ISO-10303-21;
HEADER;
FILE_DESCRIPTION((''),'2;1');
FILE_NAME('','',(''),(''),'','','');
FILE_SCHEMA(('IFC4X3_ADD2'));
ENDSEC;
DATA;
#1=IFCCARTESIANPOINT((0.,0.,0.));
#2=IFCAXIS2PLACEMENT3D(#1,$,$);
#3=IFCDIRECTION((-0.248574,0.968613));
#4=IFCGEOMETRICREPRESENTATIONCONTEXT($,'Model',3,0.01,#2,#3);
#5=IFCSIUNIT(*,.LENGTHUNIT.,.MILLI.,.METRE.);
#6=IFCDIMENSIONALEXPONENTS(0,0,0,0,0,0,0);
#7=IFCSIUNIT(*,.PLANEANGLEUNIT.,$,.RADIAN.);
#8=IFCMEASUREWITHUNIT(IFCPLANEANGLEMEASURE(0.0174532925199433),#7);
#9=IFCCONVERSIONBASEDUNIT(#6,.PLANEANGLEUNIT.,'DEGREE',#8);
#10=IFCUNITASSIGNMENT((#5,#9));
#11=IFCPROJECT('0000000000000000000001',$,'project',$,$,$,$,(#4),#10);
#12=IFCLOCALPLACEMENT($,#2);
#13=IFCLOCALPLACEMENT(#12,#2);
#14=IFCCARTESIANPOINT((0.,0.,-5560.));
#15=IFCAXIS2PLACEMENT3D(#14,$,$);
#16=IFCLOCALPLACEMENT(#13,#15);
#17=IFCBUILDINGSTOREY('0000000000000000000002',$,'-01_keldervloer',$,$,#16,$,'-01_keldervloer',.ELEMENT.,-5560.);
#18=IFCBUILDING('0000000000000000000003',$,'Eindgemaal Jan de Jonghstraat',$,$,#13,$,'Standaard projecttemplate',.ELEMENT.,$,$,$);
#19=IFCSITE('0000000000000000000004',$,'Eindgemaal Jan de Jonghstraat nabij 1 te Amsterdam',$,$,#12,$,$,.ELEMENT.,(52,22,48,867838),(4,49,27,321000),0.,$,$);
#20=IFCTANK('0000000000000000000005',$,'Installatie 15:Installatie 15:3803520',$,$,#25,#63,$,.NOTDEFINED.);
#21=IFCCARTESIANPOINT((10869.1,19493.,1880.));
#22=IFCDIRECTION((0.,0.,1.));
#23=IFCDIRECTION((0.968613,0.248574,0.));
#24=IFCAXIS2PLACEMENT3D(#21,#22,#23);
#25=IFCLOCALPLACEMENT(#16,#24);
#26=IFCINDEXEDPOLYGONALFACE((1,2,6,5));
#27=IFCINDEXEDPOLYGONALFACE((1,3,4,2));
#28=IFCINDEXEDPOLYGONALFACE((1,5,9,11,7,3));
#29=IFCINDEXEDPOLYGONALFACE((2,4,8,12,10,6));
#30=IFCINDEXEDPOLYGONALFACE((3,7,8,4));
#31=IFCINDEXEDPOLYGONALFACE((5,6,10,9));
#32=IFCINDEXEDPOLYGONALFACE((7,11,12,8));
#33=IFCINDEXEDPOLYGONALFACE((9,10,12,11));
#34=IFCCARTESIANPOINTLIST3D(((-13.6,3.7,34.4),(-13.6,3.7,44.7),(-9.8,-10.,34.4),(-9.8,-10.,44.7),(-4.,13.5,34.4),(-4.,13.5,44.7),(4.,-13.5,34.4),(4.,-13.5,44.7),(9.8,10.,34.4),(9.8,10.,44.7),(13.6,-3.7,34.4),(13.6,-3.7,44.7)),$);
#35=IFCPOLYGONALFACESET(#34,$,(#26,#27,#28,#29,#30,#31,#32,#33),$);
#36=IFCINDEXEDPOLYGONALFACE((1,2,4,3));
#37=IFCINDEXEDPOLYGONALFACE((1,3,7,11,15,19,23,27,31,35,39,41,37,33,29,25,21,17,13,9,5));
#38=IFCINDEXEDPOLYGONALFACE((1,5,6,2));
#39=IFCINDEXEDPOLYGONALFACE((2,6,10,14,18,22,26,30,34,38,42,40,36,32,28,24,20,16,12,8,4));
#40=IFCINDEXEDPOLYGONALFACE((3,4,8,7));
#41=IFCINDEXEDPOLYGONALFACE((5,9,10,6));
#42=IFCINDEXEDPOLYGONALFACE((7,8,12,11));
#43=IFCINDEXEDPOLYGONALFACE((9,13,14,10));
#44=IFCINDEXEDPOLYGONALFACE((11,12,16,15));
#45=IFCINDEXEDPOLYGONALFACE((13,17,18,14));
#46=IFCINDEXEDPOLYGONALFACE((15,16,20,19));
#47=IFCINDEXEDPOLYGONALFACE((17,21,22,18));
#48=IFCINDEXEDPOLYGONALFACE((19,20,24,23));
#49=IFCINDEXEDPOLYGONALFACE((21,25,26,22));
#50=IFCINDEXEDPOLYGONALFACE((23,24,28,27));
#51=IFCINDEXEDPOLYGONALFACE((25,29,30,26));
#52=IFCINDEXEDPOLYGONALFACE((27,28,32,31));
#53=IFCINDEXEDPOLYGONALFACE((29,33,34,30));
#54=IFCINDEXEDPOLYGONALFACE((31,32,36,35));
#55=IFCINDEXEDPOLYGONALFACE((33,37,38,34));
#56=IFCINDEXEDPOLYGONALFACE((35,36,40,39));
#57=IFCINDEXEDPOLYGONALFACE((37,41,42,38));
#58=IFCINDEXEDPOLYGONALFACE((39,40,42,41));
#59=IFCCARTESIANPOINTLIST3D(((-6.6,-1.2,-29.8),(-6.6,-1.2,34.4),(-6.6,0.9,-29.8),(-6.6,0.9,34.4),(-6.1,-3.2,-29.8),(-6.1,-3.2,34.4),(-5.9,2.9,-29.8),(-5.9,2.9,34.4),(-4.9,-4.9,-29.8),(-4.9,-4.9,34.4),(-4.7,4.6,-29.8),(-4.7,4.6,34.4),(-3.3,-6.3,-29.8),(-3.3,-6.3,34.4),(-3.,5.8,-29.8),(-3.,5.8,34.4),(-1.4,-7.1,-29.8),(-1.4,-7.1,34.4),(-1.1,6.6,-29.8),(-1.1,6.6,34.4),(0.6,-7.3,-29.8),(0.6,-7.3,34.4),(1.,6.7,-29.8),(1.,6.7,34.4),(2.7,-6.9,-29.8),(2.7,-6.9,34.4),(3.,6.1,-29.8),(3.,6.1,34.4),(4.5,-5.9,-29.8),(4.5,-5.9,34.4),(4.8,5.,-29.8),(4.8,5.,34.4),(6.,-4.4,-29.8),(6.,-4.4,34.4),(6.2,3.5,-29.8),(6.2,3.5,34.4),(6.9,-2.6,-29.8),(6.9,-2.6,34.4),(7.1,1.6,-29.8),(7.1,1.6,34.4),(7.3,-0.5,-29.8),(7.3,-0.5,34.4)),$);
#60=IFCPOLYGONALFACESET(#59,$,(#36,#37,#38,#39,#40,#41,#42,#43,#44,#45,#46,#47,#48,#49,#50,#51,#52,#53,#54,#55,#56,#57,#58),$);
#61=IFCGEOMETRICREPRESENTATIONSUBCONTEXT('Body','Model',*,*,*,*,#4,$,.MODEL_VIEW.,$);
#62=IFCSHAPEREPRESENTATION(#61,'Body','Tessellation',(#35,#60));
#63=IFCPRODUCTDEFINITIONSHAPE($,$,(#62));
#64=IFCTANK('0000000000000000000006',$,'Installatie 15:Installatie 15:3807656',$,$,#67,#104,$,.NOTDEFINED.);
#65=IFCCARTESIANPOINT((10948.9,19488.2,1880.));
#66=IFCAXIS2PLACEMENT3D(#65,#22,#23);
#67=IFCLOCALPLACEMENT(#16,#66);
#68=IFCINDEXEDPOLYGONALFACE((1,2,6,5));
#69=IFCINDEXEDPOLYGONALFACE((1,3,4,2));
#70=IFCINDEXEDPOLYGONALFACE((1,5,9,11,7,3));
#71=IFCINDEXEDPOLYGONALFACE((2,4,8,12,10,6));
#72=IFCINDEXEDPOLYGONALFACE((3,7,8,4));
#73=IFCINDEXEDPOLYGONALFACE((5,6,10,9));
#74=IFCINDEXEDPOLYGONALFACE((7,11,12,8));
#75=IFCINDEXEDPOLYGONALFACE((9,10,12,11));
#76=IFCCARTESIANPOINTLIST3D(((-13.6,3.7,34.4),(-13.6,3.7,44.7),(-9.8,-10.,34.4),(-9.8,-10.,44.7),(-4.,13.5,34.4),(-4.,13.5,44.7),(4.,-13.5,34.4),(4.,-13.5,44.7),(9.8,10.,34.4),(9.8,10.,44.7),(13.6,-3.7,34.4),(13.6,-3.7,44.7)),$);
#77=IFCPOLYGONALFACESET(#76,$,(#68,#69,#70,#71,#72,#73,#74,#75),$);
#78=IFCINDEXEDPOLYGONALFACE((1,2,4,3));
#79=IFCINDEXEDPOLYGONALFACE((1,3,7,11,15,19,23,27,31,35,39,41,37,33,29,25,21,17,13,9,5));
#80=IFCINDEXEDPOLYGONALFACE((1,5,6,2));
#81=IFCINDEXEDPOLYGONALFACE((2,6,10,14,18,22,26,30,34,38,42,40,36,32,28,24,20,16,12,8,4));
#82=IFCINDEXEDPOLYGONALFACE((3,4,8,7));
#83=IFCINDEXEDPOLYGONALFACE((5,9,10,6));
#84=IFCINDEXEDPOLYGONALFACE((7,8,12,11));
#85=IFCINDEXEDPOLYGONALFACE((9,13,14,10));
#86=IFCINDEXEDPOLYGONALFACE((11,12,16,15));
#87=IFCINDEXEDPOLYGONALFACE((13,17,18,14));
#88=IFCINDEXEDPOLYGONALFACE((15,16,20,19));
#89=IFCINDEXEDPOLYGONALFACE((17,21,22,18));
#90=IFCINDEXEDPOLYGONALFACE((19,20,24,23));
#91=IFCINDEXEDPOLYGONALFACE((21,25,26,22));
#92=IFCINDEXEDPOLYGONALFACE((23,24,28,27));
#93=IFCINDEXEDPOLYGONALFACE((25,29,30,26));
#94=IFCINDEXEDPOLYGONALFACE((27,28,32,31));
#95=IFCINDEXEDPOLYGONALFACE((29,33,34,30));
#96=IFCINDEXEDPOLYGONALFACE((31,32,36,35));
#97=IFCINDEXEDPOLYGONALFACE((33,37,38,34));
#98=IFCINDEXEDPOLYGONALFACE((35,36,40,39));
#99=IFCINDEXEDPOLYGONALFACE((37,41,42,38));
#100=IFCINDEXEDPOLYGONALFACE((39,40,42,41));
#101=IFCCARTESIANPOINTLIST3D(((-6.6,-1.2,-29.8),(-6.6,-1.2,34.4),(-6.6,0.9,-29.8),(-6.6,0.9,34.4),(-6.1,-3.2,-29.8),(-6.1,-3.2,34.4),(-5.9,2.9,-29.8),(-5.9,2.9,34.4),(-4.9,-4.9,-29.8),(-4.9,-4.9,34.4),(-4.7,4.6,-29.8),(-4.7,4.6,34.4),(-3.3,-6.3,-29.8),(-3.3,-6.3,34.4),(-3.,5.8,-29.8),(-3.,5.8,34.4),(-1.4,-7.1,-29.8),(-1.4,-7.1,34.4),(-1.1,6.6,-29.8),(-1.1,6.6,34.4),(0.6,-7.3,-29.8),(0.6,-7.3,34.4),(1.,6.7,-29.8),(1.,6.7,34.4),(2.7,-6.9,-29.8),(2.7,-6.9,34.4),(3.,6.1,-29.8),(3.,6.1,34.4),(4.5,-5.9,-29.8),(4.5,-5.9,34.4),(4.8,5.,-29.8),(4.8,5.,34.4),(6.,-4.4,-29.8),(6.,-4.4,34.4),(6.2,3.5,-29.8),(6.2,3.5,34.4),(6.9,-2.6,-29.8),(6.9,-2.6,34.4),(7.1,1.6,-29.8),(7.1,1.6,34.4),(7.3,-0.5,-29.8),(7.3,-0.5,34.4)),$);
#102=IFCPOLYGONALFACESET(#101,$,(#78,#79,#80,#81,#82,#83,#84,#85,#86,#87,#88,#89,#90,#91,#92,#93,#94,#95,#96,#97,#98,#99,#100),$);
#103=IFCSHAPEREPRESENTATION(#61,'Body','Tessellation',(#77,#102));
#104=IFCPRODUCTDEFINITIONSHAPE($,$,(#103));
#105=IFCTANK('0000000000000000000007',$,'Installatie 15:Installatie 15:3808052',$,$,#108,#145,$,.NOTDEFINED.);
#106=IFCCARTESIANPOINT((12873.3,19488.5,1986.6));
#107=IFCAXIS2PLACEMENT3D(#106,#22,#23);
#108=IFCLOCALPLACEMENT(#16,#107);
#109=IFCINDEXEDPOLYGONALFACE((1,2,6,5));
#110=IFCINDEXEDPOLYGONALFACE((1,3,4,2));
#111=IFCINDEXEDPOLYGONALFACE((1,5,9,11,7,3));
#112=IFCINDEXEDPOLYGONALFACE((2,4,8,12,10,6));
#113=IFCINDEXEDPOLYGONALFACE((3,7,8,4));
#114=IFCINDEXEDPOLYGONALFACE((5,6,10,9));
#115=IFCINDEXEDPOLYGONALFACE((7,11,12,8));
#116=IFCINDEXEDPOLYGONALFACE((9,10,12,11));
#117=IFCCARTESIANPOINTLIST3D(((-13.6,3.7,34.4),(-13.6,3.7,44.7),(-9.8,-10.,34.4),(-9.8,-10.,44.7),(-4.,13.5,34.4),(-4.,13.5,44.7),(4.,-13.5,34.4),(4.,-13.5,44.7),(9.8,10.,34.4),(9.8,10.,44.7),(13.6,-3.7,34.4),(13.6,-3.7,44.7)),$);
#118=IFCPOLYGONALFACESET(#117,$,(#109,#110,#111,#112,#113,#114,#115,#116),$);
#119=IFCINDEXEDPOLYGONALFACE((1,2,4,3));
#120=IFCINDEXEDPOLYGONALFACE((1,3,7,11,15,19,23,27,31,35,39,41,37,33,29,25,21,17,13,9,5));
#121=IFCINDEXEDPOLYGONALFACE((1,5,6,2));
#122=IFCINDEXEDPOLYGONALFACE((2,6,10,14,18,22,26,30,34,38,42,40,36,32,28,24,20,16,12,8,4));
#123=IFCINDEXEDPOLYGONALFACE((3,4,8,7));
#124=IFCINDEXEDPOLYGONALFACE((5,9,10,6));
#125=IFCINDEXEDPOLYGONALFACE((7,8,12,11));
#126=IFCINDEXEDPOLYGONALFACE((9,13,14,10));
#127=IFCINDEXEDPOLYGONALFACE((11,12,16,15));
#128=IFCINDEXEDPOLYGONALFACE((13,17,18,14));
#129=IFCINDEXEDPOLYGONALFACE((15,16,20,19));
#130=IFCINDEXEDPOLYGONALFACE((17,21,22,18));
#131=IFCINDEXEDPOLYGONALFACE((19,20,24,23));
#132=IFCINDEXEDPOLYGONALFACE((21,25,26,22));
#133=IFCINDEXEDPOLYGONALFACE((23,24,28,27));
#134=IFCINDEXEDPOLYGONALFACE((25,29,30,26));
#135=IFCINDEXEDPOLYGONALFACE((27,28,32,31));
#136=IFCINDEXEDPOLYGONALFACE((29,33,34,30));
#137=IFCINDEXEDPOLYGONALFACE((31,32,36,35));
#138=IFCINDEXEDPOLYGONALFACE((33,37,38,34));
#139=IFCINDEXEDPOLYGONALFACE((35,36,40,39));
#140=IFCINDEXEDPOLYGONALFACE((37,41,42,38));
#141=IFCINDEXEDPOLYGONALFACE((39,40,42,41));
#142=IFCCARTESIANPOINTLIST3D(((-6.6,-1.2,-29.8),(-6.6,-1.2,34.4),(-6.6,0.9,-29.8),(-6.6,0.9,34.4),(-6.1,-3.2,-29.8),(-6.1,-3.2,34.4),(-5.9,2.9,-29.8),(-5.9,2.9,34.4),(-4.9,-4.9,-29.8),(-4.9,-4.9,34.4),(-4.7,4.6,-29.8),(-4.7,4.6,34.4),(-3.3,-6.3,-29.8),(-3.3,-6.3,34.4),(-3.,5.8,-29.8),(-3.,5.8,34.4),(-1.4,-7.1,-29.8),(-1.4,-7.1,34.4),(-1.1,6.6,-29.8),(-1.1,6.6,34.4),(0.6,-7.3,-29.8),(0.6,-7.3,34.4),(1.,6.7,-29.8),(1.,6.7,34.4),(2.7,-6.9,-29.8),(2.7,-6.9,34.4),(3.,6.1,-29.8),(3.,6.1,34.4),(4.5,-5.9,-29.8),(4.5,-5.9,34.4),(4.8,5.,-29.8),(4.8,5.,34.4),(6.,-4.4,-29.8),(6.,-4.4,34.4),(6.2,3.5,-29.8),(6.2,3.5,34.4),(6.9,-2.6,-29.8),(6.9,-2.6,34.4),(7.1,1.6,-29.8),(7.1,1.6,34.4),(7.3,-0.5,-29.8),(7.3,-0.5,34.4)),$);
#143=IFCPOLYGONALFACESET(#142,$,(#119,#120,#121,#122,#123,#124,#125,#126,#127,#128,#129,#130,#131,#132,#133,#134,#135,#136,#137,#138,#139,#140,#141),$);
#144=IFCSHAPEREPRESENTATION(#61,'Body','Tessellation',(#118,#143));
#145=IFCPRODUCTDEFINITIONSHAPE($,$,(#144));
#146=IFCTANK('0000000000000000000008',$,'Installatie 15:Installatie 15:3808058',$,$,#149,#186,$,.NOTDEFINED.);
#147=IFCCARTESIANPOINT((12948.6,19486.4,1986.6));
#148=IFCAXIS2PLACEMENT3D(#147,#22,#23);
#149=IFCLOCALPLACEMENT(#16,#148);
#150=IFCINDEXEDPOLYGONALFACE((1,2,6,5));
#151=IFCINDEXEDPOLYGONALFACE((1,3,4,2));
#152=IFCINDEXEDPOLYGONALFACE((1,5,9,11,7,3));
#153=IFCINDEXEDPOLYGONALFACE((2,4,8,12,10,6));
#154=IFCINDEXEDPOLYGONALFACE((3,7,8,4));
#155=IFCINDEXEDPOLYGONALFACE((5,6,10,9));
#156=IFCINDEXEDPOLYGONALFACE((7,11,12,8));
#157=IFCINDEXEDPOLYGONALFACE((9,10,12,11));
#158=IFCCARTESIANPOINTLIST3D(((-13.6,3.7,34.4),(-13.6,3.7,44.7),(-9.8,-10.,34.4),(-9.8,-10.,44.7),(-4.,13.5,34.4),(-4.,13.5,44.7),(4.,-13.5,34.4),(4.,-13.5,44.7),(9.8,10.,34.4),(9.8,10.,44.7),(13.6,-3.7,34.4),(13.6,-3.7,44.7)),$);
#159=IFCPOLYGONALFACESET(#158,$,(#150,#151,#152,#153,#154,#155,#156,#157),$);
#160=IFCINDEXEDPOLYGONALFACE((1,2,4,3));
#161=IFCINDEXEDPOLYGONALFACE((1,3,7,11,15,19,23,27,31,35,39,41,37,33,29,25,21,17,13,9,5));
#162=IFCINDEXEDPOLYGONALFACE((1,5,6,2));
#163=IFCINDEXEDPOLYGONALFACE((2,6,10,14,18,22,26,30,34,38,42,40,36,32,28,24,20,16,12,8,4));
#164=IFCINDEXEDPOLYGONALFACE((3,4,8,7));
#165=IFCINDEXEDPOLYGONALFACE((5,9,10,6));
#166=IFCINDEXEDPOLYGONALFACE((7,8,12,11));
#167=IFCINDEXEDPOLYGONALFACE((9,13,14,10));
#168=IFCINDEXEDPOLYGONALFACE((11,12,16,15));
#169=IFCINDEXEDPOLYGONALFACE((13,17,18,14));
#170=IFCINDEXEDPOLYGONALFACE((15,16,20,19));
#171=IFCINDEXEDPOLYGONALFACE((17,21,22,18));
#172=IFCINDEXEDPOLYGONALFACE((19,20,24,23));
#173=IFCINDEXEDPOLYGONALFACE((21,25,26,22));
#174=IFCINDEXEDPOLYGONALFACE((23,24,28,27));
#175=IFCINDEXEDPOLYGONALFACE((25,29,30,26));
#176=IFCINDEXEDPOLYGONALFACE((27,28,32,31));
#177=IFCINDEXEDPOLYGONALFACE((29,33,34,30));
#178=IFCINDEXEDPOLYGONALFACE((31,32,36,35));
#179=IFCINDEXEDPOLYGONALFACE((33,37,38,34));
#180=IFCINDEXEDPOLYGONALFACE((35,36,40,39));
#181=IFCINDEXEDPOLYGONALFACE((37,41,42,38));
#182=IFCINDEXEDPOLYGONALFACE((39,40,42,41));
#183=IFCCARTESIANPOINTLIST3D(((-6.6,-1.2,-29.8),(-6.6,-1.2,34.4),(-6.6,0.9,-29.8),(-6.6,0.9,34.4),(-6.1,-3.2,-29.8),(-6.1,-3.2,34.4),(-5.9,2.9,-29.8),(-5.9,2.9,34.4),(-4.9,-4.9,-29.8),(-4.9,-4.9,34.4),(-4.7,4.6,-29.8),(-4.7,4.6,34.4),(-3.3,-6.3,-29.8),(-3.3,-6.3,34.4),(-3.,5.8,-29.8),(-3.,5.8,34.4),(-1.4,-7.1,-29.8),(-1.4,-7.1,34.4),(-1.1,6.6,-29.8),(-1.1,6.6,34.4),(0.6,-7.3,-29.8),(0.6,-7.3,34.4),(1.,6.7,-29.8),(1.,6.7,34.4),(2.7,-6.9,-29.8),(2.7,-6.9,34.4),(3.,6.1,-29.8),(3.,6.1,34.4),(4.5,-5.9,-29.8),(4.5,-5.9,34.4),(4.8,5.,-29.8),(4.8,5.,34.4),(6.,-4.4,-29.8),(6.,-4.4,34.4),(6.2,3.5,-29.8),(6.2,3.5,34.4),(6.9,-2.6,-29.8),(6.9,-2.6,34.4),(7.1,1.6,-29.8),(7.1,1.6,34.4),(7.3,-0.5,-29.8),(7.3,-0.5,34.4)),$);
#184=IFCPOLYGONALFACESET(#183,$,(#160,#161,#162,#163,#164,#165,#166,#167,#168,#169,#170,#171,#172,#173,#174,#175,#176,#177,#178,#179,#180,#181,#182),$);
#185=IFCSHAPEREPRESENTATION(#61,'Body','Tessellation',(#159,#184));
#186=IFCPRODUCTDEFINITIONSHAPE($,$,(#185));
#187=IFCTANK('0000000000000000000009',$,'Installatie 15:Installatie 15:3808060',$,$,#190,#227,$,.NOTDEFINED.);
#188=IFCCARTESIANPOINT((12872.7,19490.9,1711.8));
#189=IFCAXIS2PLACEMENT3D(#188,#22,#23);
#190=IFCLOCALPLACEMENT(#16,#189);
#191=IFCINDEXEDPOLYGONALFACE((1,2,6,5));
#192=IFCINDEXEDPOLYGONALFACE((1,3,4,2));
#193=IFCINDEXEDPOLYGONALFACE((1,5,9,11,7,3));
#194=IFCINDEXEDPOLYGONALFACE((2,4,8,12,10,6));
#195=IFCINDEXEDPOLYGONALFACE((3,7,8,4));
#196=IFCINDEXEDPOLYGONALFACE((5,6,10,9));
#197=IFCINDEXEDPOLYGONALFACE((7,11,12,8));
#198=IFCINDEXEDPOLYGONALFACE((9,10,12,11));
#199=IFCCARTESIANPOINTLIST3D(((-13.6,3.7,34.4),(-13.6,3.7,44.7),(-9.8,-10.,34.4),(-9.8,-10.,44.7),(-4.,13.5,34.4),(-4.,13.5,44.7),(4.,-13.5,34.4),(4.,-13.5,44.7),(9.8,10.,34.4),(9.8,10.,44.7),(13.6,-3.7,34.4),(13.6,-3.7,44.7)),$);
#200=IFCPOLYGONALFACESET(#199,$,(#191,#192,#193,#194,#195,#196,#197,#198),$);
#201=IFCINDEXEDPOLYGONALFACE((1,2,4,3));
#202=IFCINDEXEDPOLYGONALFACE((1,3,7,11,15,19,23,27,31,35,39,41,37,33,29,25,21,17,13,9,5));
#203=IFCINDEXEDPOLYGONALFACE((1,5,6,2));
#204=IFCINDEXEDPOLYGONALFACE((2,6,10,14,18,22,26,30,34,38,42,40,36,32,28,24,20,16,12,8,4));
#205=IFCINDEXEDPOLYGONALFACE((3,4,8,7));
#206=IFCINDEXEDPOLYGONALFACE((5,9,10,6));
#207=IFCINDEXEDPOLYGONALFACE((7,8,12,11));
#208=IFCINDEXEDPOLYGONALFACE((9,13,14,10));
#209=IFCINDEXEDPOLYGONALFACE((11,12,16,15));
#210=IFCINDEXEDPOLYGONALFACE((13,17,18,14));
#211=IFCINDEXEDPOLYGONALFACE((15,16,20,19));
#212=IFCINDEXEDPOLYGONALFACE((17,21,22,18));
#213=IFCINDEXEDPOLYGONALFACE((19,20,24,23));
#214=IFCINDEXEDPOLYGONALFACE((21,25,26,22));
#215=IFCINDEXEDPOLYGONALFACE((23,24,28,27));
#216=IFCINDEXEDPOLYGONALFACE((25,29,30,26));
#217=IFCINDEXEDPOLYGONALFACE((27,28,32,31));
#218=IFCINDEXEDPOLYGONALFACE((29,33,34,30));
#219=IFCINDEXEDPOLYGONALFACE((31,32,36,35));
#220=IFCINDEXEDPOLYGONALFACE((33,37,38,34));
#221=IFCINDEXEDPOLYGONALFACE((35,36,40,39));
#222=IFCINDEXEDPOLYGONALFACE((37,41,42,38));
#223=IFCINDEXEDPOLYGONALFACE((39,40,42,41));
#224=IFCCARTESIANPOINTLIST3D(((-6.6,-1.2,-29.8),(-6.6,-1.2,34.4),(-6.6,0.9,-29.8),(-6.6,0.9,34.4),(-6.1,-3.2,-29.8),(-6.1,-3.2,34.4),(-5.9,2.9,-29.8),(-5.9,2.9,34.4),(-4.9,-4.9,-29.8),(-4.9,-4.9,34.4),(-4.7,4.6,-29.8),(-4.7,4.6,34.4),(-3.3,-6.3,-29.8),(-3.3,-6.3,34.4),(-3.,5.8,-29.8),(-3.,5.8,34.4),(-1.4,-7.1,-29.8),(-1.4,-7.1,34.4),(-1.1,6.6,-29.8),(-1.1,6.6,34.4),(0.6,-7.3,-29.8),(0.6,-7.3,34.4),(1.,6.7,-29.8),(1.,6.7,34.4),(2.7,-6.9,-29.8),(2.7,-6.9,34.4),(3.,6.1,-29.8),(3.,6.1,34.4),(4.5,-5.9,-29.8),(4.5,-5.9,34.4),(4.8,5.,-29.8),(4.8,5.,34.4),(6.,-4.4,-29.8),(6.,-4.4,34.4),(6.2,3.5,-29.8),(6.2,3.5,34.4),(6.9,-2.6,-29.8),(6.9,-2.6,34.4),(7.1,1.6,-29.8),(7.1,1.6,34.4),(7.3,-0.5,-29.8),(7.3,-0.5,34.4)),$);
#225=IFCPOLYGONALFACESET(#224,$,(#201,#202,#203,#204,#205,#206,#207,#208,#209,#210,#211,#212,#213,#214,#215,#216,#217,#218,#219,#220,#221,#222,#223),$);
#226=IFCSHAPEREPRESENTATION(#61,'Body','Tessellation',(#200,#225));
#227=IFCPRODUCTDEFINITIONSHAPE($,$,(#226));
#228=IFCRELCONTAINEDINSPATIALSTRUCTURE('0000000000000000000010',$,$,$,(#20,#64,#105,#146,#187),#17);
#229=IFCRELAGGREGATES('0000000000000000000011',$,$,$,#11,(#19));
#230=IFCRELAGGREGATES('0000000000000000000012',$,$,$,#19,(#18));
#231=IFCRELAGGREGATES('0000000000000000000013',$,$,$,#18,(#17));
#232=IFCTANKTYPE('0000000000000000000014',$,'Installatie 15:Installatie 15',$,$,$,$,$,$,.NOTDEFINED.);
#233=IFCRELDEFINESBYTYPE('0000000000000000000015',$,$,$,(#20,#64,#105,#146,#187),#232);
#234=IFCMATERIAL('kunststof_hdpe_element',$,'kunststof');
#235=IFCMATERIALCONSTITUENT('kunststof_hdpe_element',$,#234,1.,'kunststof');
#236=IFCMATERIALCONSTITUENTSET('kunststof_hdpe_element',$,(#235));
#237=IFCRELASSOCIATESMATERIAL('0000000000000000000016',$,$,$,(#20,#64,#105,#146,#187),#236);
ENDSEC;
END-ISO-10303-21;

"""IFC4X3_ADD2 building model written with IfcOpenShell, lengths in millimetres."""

from ifc_helpers import new_model, entity, si_unit, converted_unit, direction, frame, frame_2d, origin, place, context, subcontext, project, spatial, polyline, circle, outline, extrude, source, transform, mapped, material, constituent, constituent_set, type_object, type_shapes, element, save


model = new_model("IFC4X3_ADD2")

# Units and contexts
model_context = context("Model", 3, precision=0.01, world=origin(), true_north=direction((-0.248574, 0.968613)))
body_context = subcontext(model_context, "Body", "Model", "MODEL_VIEW")
ifc_project = project(units=[si_unit("LENGTHUNIT", "METRE", prefix="MILLI"), converted_unit("PLANEANGLEUNIT", "DEGREE", entity("IfcPlaneAngleMeasure", 0.0174532925199433), si_unit("PLANEANGLEUNIT", "RADIAN"), dimensions=[0, 0, 0, 0, 0, 0, 0])], contexts=[model_context])

# Site, building, storey
site_placement = place(None, origin())
site = spatial("IfcSite", under=ifc_project, at=site_placement, Name="Eindgemaal Jan de Jonghstraat nabij 1 te Amsterdam", CompositionType="ELEMENT", RefLatitude=(52, 22, 48, 867838), RefLongitude=(4, 49, 27, 321000), RefElevation=0.0)
building_placement = place(site_placement, origin())
building = spatial("IfcBuilding", under=site, at=building_placement, Name="Eindgemaal Jan de Jonghstraat", LongName="Standaard projecttemplate", CompositionType="ELEMENT")
storey_placement = place(building_placement, frame((0.0, 0.0, -5560.0)))
storey = spatial("IfcBuildingStorey", under=building, at=storey_placement, Name="-01_keldervloer", LongName="-01_keldervloer", CompositionType="ELEMENT", Elevation=-5560.0)

# Tanks
ifc_material_1 = material(Name="kunststof_hdpe_element", Category="kunststof")
ifc_constituent_1 = constituent(ifc_material_1, Name="kunststof_hdpe_element", Category="kunststof", fraction=1.0)
ifc_constituent_set_1 = constituent_set(constituents=[ifc_constituent_1], Name="kunststof_hdpe_element")
tank_type_1 = type_object("IfcTankType", Name="Installatie 15:Installatie 15", PredefinedType="NOTDEFINED")
shared_shape_1 = source(origin(), body_context, "Body", "SweptSolid", [
    extrude(outline(polyline([(-7.0, -12.1), (7.3, -12.1), (14.1, -0.2), (7.0, 12.1), (-7.3, 12.1), (-14.1, 0.2), (-7.0, -12.1)])), frame((0.0, 0.0, 34.4), z_axis=(0.0, 0.0, 1.0), x_axis=(-0.968613, 0.248574, 0.0)), (0.0, 0.0, 1.0), 10.3),
    extrude(circle(Radius=7.0, at=frame_2d((0.0, 0.0), x_axis=(1.0, 0.0))), frame((0.3, -0.3, -29.8), z_axis=(0.0, 0.0, 1.0), x_axis=(-0.248574, -0.968613, 0.0)), (0.0, 0.0, 1.0), 64.2),
])
type_shapes(tank_type_1, [shared_shape_1])
for number, where, z_axis, x_axis, name in (
    (1, (10869.1, 19493.0, 1880.0), (0.0, 0.0, 1.0), (0.968613, 0.248574, 0.0), "Installatie 15:Installatie 15:3803520"),
    (2, (10948.9, 19488.2, 1880.0), (0.0, 0.0, 1.0), (0.968613, 0.248574, 0.0), "Installatie 15:Installatie 15:3807656"),
    (3, (12873.3, 19488.5, 1986.6), (0.0, 0.0, 1.0), (0.968613, 0.248574, 0.0), "Installatie 15:Installatie 15:3808052"),
    (4, (12948.6, 19486.4, 1986.6), (0.0, 0.0, 1.0), (0.968613, 0.248574, 0.0), "Installatie 15:Installatie 15:3808058"),
    (5, (12872.7, 19490.9, 1711.8), (0.0, 0.0, 1.0), (0.968613, 0.248574, 0.0), "Installatie 15:Installatie 15:3808060"),
):
    element("IfcTank", number, at=place(storey_placement, frame(where, z_axis=z_axis, x_axis=x_axis)), inside=storey, type_object=tank_type_1, material=ifc_constituent_set_1, Name=name, PredefinedType="NOTDEFINED", context=body_context, shape_type="MappedRepresentation", body=[
        mapped(shared_shape_1, transform((0.0, 0.0, 0.0), scale=1.0)),
    ])

save(model, "model.ifc")
